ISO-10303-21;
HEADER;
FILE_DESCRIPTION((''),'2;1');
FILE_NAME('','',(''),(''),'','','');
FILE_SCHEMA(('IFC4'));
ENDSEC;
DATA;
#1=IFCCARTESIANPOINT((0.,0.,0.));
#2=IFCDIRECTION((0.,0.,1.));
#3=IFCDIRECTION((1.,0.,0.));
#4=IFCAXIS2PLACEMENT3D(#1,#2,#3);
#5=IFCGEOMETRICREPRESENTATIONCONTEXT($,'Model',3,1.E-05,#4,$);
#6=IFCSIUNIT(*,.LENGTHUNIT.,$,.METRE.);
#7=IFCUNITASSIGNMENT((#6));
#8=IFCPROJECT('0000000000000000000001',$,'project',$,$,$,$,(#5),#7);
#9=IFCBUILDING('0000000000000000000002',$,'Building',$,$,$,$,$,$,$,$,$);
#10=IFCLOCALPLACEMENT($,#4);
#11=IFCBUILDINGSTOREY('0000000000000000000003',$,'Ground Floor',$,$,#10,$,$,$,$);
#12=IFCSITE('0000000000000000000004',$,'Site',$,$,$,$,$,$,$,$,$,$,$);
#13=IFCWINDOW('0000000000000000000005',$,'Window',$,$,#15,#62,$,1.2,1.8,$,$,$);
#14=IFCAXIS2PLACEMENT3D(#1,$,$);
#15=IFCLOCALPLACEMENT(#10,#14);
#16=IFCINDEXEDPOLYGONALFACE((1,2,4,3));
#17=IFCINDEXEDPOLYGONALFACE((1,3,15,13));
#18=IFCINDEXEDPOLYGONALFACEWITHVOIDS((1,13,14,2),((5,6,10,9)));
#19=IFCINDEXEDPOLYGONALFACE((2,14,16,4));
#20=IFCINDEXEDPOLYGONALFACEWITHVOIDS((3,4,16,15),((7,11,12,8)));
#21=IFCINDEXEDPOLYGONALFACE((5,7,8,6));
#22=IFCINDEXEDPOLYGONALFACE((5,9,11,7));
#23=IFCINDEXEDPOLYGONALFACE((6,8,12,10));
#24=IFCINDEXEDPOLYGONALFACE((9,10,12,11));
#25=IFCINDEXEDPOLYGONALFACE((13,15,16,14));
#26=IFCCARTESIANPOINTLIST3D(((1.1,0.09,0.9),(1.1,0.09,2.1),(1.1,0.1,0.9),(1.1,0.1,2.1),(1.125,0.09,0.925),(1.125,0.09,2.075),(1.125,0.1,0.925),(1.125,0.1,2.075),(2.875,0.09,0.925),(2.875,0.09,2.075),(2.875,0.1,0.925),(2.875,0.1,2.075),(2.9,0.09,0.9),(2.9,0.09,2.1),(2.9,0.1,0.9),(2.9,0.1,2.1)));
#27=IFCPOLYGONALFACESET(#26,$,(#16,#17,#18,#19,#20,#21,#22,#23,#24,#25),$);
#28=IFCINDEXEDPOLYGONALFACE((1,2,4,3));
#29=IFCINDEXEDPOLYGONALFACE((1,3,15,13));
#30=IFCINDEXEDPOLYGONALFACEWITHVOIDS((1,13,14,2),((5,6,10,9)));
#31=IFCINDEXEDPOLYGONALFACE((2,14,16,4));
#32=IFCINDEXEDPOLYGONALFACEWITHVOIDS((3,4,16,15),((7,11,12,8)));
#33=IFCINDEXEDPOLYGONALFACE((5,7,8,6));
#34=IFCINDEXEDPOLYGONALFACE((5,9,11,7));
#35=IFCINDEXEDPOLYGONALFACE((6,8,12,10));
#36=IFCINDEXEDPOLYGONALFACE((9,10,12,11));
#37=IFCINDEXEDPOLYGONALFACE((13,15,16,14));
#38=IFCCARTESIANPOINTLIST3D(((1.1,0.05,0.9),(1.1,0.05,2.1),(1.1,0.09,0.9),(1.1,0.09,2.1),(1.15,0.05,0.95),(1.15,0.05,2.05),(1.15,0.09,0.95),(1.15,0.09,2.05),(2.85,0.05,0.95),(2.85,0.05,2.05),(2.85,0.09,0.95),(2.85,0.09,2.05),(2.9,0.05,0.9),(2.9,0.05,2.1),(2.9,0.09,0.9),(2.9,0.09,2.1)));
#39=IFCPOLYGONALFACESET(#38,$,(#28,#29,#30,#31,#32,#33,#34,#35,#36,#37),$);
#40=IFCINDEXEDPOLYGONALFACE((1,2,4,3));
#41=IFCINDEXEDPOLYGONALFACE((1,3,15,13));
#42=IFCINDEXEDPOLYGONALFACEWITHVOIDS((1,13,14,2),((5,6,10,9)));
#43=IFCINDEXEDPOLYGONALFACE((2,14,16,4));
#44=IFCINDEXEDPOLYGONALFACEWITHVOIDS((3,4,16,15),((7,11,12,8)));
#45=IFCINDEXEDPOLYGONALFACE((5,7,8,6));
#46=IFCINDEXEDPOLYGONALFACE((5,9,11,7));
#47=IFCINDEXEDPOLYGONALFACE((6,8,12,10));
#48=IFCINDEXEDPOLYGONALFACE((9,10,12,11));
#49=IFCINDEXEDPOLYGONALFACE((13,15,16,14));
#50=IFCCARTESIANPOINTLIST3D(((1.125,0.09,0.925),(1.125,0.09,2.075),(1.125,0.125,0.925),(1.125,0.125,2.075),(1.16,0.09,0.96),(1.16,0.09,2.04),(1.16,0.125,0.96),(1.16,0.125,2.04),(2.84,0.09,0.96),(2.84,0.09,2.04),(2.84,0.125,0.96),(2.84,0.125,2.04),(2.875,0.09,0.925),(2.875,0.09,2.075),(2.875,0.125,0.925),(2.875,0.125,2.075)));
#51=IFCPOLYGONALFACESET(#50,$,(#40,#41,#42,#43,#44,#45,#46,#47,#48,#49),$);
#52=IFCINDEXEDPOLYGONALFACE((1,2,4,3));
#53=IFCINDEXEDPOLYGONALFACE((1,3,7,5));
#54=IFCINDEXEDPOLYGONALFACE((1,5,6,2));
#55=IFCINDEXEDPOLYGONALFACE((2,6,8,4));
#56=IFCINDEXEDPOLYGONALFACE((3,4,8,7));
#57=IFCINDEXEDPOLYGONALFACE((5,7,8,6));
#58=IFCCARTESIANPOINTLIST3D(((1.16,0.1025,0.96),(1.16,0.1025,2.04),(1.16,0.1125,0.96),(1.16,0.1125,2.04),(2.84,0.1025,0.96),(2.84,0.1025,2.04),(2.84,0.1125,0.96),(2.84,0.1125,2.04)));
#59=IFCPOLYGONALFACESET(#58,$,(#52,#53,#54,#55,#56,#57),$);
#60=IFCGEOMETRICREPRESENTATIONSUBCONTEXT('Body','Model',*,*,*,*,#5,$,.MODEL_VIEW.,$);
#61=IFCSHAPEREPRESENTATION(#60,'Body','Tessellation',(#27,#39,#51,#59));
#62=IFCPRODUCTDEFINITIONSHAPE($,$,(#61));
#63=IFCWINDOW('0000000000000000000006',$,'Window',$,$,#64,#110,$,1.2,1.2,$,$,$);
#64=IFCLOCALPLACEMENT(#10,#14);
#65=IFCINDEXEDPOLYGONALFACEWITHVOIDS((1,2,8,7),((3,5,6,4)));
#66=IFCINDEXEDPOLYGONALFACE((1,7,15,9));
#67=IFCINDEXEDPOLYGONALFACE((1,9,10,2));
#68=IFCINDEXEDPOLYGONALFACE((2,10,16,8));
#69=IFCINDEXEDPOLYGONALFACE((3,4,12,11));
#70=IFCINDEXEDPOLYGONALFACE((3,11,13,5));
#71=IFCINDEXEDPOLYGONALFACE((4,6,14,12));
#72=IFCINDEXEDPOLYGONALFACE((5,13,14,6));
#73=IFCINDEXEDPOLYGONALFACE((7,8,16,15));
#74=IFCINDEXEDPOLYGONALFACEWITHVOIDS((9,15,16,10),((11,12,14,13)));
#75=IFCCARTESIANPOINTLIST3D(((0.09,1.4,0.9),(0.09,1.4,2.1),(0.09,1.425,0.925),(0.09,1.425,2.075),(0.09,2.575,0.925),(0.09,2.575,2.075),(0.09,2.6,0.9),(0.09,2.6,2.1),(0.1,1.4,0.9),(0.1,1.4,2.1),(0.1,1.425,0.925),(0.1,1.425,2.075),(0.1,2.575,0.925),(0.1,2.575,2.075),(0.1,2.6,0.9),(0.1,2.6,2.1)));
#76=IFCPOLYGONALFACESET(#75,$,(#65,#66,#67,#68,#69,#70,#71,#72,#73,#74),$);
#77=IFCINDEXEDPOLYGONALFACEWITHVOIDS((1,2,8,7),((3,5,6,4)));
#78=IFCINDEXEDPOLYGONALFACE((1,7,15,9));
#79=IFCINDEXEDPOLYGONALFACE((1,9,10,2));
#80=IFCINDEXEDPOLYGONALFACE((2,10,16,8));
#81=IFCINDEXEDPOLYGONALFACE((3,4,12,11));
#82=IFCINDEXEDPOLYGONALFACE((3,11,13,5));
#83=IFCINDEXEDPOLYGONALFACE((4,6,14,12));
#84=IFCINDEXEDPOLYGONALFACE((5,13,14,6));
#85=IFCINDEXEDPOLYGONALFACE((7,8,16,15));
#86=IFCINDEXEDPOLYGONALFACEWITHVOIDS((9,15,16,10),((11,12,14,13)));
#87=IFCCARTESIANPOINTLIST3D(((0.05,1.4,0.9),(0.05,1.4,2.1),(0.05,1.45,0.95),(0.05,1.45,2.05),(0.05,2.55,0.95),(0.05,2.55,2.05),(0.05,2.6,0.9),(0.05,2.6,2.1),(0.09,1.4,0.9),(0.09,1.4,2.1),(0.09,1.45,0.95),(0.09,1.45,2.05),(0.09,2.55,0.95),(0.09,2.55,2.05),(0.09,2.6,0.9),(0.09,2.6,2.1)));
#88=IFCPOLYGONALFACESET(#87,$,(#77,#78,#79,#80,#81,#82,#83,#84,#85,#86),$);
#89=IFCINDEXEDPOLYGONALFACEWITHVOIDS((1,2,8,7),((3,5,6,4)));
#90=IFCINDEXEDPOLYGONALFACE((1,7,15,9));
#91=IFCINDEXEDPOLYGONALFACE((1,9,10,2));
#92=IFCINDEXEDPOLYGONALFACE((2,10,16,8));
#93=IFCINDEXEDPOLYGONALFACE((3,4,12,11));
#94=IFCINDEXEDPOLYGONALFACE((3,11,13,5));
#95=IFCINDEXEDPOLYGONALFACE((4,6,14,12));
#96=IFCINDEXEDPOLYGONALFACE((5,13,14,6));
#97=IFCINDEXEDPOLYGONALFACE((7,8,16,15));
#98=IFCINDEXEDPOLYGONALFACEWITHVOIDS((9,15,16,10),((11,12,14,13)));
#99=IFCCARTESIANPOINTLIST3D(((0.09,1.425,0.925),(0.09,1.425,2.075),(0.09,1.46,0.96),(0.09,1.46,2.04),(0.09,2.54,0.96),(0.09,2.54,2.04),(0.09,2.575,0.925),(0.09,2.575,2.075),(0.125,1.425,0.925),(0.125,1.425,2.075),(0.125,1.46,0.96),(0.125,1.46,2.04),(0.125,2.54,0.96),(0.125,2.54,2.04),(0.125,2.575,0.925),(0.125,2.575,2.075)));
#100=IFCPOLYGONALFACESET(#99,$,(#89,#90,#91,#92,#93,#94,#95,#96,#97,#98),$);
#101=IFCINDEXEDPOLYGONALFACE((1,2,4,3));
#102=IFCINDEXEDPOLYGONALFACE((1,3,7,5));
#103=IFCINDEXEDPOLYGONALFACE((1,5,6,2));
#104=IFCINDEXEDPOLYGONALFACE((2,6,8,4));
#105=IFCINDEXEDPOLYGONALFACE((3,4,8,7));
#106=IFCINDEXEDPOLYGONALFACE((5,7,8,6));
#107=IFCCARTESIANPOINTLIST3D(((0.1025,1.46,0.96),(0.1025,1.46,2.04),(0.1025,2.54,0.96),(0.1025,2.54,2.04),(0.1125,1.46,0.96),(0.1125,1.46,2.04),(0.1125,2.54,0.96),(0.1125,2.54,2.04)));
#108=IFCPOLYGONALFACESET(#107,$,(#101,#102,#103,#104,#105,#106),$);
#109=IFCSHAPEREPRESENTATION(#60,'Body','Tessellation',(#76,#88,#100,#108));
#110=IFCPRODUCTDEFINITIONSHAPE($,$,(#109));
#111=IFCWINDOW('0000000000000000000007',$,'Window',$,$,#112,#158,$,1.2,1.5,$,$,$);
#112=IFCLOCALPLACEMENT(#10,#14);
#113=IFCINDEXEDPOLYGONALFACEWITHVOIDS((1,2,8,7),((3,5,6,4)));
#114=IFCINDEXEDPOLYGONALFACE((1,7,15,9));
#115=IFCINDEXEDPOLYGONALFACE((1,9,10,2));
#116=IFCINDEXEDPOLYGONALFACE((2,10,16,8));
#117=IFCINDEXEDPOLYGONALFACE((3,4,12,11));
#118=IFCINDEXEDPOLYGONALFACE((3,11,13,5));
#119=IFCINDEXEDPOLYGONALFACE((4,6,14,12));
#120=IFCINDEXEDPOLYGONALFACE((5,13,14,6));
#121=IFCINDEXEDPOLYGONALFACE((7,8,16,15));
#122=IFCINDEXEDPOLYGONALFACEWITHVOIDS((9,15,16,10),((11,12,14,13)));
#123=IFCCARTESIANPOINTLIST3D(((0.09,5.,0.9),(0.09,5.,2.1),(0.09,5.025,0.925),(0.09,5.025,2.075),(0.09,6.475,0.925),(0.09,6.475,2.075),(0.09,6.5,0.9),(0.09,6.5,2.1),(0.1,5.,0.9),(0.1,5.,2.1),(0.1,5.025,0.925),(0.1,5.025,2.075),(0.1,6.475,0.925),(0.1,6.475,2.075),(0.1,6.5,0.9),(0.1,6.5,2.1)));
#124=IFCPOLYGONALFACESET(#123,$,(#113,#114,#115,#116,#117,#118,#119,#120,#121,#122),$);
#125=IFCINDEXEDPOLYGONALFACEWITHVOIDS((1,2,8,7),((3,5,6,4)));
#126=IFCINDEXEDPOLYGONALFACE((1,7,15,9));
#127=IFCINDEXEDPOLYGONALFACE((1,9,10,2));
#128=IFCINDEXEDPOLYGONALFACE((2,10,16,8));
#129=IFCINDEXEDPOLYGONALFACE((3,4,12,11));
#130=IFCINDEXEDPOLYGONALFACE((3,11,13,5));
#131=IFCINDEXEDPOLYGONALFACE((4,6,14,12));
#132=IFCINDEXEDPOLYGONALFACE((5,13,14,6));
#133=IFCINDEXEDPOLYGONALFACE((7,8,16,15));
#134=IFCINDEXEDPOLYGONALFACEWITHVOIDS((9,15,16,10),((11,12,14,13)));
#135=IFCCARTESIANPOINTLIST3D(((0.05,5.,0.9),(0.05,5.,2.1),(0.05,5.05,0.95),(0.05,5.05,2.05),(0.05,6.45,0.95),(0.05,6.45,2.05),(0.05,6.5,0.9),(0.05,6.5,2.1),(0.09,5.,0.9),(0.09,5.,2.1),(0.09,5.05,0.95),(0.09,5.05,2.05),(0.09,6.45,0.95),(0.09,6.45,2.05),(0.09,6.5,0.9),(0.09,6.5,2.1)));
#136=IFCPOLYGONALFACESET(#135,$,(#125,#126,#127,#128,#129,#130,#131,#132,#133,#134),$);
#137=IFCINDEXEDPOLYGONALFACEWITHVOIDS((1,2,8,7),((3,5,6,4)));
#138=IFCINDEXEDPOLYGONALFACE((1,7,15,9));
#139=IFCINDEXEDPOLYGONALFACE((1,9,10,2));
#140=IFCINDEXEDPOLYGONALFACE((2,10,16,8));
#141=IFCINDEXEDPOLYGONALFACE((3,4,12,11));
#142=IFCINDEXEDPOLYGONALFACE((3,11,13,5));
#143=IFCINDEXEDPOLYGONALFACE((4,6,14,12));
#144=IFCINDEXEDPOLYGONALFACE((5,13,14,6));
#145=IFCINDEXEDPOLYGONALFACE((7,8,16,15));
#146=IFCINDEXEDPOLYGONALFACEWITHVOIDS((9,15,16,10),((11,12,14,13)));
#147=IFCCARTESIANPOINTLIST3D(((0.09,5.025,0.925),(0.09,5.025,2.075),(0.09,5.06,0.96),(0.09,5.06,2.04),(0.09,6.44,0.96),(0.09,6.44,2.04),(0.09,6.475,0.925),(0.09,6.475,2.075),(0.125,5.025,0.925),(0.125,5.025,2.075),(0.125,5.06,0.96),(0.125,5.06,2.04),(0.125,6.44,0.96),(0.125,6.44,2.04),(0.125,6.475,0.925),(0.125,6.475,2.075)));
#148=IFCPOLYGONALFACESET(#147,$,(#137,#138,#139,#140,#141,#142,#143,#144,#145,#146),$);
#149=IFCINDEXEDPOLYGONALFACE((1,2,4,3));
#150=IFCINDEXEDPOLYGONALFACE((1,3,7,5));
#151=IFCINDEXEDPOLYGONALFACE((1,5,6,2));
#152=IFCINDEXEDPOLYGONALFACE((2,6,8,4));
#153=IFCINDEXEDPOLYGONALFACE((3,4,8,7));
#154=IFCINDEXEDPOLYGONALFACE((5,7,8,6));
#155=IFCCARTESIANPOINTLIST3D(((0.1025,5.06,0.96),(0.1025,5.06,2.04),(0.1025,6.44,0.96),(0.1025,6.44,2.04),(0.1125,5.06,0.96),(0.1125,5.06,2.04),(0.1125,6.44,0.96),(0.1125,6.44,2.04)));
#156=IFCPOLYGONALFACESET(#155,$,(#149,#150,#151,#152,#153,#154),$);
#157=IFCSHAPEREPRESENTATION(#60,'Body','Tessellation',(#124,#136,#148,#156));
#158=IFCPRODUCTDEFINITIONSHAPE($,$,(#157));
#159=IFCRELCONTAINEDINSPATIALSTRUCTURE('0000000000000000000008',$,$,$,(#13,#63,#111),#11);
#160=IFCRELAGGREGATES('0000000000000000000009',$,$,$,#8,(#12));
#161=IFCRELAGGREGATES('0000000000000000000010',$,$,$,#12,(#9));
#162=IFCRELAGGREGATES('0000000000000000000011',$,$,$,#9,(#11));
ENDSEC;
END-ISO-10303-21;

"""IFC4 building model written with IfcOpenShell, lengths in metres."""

from ifc_helpers import new_model, si_unit, frame, origin_with_axes, place, context, subcontext, project, spatial, line, indexed_curve, outline, extrude, element, save


model = new_model("IFC4")

# Units and contexts
model_context = context("Model", 3, precision=1e-05, world=origin_with_axes())
body_context = subcontext(model_context, "Body", "Model", "MODEL_VIEW")
ifc_project = project(units=[si_unit("LENGTHUNIT", "METRE")], contexts=[model_context])

# Site, building, storey
site = spatial("IfcSite", under=ifc_project, Name="Site")
building = spatial("IfcBuilding", under=site, Name="Building")
storey_placement = place(None, origin_with_axes())
storey = spatial("IfcBuildingStorey", under=building, at=storey_placement, Name="Ground Floor")

# Windows
window_1_placement = place(storey_placement, frame((1.1, 0.0, 0.9), z_axis=(0.0, 0.0, 1.0), x_axis=(1.0, 0.0, 0.0)))
element("IfcWindow", 1, at=window_1_placement, inside=storey, Name="Window", OverallHeight=1.2, OverallWidth=1.8, context=body_context, shape_type="SweptSolid", body=[
    extrude(outline(indexed_curve([(0.0, 0.0), (1.8, 0.0), (1.8, 1.2), (0.0, 1.2)], segments=[line(1, 2, 3, 4, 1)]), holes=[indexed_curve([(0.025, 0.025), (1.775, 0.025), (1.775, 1.175), (0.025, 1.175)], segments=[line(1, 2, 3, 4, 1)])]), frame((0.0, 0.09, 0.0), z_axis=(0.0, -1.0, 0.0), x_axis=(1.0, 0.0, 0.0)), (0.0, 0.0, -1.0), 0.01),
    extrude(outline(indexed_curve([(0.0, 0.0), (1.8, 0.0), (1.8, 1.2), (0.0, 1.2)], segments=[line(1, 2, 3, 4, 1)]), holes=[indexed_curve([(0.05, 0.05), (1.75, 0.05), (1.75, 1.15), (0.05, 1.15)], segments=[line(1, 2, 3, 4, 1)])]), frame((0.0, 0.05, 0.0), z_axis=(0.0, -1.0, 0.0), x_axis=(1.0, 0.0, 0.0)), (0.0, 0.0, -1.0), 0.04),
    extrude(outline(indexed_curve([(0.0, 0.0), (1.75, 0.0), (1.75, 1.15), (0.0, 1.15)], segments=[line(1, 2, 3, 4, 1)]), holes=[indexed_curve([(0.035, 0.035), (1.715, 0.035), (1.715, 1.115), (0.035, 1.115)], segments=[line(1, 2, 3, 4, 1)])]), frame((0.025, 0.09, 0.025), z_axis=(0.0, -1.0, 0.0), x_axis=(1.0, 0.0, 0.0)), (0.0, 0.0, -1.0), 0.035),
    extrude(outline(indexed_curve([(0.035, 0.035), (1.715, 0.035), (1.715, 1.115), (0.035, 1.115)], segments=[line(1, 2, 3, 4, 1)])), frame((0.025, 0.1025, 0.025), z_axis=(0.0, -1.0, 0.0), x_axis=(1.0, 0.0, 0.0)), (0.0, 0.0, -1.0), 0.01),
])
window_2_placement = place(storey_placement, frame((0.0, 2.6, 0.9), z_axis=(0.0, 0.0, 1.0), x_axis=(0.0, -1.0, 0.0)))
element("IfcWindow", 2, at=window_2_placement, inside=storey, Name="Window", OverallHeight=1.2, OverallWidth=1.2, context=body_context, shape_type="SweptSolid", body=[
    extrude(outline(indexed_curve([(0.0, 0.0), (1.2, 0.0), (1.2, 1.2), (0.0, 1.2)], segments=[line(1, 2, 3, 4, 1)]), holes=[indexed_curve([(0.025, 0.025), (1.175, 0.025), (1.175, 1.175), (0.025, 1.175)], segments=[line(1, 2, 3, 4, 1)])]), frame((0.0, 0.09, 0.0), z_axis=(0.0, -1.0, 0.0), x_axis=(1.0, 0.0, 0.0)), (0.0, 0.0, -1.0), 0.01),
    extrude(outline(indexed_curve([(0.0, 0.0), (1.2, 0.0), (1.2, 1.2), (0.0, 1.2)], segments=[line(1, 2, 3, 4, 1)]), holes=[indexed_curve([(0.05, 0.05), (1.15, 0.05), (1.15, 1.15), (0.05, 1.15)], segments=[line(1, 2, 3, 4, 1)])]), frame((0.0, 0.05, 0.0), z_axis=(0.0, -1.0, 0.0), x_axis=(1.0, 0.0, 0.0)), (0.0, 0.0, -1.0), 0.04),
    extrude(outline(indexed_curve([(0.0, 0.0), (1.15, 0.0), (1.15, 1.15), (0.0, 1.15)], segments=[line(1, 2, 3, 4, 1)]), holes=[indexed_curve([(0.035, 0.035), (1.115, 0.035), (1.115, 1.115), (0.035, 1.115)], segments=[line(1, 2, 3, 4, 1)])]), frame((0.025, 0.09, 0.025), z_axis=(0.0, -1.0, 0.0), x_axis=(1.0, 0.0, 0.0)), (0.0, 0.0, -1.0), 0.035),
    extrude(outline(indexed_curve([(0.035, 0.035), (1.115, 0.035), (1.115, 1.115), (0.035, 1.115)], segments=[line(1, 2, 3, 4, 1)])), frame((0.025, 0.1025, 0.025), z_axis=(0.0, -1.0, 0.0), x_axis=(1.0, 0.0, 0.0)), (0.0, 0.0, -1.0), 0.01),
])
window_3_placement = place(storey_placement, frame((0.0, 6.5, 0.9), z_axis=(0.0, 0.0, 1.0), x_axis=(0.0, -1.0, 0.0)))
element("IfcWindow", 3, at=window_3_placement, inside=storey, Name="Window", OverallHeight=1.2, OverallWidth=1.5, context=body_context, shape_type="SweptSolid", body=[
    extrude(outline(indexed_curve([(0.0, 0.0), (1.5, 0.0), (1.5, 1.2), (0.0, 1.2)], segments=[line(1, 2, 3, 4, 1)]), holes=[indexed_curve([(0.025, 0.025), (1.475, 0.025), (1.475, 1.175), (0.025, 1.175)], segments=[line(1, 2, 3, 4, 1)])]), frame((0.0, 0.09, 0.0), z_axis=(0.0, -1.0, 0.0), x_axis=(1.0, 0.0, 0.0)), (0.0, 0.0, -1.0), 0.01),
    extrude(outline(indexed_curve([(0.0, 0.0), (1.5, 0.0), (1.5, 1.2), (0.0, 1.2)], segments=[line(1, 2, 3, 4, 1)]), holes=[indexed_curve([(0.05, 0.05), (1.45, 0.05), (1.45, 1.15), (0.05, 1.15)], segments=[line(1, 2, 3, 4, 1)])]), frame((0.0, 0.05, 0.0), z_axis=(0.0, -1.0, 0.0), x_axis=(1.0, 0.0, 0.0)), (0.0, 0.0, -1.0), 0.04),
    extrude(outline(indexed_curve([(0.0, 0.0), (1.45, 0.0), (1.45, 1.15), (0.0, 1.15)], segments=[line(1, 2, 3, 4, 1)]), holes=[indexed_curve([(0.035, 0.035), (1.415, 0.035), (1.415, 1.115), (0.035, 1.115)], segments=[line(1, 2, 3, 4, 1)])]), frame((0.025, 0.09, 0.025), z_axis=(0.0, -1.0, 0.0), x_axis=(1.0, 0.0, 0.0)), (0.0, 0.0, -1.0), 0.035),
    extrude(outline(indexed_curve([(0.035, 0.035), (1.415, 0.035), (1.415, 1.115), (0.035, 1.115)], segments=[line(1, 2, 3, 4, 1)])), frame((0.025, 0.1025, 0.025), z_axis=(0.0, -1.0, 0.0), x_axis=(1.0, 0.0, 0.0)), (0.0, 0.0, -1.0), 0.01),
])

save(model, "model.ifc")
